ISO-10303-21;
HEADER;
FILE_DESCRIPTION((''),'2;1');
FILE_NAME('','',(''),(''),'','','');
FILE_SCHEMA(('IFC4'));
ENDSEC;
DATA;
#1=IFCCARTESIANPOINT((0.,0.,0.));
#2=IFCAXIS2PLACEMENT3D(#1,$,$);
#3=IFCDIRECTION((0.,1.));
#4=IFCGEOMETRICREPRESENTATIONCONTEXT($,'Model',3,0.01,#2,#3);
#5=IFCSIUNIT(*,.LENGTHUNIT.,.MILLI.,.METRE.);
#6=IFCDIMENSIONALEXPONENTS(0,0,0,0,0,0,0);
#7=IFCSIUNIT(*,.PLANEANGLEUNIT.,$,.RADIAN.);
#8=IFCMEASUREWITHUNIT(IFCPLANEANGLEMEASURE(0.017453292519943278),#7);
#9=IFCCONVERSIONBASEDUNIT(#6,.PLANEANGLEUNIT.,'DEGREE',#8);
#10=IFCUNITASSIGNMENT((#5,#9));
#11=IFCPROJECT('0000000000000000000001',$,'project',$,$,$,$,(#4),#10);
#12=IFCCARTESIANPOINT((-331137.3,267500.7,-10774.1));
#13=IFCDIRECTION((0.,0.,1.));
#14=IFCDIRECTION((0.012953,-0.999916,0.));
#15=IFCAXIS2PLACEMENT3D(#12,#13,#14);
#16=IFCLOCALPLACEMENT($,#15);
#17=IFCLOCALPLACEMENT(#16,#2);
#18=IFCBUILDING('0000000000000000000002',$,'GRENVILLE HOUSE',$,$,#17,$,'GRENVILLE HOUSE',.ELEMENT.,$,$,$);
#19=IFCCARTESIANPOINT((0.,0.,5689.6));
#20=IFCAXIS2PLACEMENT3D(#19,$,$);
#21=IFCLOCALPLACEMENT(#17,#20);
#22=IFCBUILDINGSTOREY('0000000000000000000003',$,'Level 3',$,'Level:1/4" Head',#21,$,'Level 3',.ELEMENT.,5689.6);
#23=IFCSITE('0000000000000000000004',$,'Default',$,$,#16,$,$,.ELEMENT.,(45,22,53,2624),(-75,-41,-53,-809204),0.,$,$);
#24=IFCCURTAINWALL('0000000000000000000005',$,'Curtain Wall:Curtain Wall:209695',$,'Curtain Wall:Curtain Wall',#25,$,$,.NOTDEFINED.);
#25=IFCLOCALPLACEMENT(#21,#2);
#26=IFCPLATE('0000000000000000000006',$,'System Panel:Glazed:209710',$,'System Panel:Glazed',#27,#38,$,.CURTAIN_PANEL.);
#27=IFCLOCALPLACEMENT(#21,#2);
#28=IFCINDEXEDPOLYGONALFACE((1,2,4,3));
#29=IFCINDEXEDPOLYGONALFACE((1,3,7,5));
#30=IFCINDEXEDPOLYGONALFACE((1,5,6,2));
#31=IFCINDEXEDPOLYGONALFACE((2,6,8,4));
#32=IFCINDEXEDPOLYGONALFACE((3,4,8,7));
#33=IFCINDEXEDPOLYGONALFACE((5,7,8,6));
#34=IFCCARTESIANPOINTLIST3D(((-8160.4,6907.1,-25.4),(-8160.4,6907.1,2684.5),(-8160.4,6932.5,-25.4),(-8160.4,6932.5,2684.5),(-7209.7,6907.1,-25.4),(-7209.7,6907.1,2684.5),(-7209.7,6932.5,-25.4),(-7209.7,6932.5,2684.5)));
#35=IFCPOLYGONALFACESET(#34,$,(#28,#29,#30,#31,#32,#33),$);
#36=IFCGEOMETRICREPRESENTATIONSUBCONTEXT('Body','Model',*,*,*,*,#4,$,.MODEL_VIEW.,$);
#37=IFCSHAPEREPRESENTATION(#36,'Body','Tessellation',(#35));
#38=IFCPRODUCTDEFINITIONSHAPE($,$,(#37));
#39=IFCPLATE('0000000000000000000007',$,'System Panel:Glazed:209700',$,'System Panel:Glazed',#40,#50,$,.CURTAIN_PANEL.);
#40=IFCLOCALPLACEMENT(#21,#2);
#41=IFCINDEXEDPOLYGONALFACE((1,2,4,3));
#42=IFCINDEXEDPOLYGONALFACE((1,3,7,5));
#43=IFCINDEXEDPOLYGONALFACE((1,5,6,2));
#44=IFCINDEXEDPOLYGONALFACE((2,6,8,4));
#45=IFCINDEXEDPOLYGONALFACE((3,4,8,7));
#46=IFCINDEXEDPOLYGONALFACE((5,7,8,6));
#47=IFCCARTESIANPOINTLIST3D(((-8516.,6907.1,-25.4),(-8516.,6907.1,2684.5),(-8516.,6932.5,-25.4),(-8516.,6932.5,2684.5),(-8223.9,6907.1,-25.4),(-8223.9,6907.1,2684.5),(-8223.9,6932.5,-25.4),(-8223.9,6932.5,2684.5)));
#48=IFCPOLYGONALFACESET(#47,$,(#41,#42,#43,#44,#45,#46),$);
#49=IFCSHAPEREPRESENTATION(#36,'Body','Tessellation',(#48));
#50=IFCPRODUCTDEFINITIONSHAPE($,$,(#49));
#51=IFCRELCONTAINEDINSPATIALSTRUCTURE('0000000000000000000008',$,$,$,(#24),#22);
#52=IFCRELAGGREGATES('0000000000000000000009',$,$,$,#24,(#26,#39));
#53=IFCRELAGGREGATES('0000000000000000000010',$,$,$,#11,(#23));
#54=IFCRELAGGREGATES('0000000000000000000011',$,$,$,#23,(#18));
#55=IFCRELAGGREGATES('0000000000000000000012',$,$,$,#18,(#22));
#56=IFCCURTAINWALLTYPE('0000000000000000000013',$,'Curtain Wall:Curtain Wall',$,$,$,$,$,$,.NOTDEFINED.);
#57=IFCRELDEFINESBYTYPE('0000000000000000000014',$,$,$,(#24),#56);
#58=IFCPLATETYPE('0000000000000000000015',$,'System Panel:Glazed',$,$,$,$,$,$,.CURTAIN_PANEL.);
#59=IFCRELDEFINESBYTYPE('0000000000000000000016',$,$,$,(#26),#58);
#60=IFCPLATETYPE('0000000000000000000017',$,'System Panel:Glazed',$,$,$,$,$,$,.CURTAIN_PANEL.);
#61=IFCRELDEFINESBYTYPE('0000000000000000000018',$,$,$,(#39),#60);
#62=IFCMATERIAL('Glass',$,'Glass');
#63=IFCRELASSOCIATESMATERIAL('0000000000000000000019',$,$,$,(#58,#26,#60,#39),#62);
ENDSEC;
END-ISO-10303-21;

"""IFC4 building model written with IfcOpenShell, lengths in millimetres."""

from ifc_helpers import new_model, entity, si_unit, converted_unit, direction, frame, origin, place, context, subcontext, project, spatial, indexed_curve, outline, extrude, source, transform, mapped, material, type_object, type_shapes, element, aggregate, save


model = new_model("IFC4")

# Units and contexts
model_context = context("Model", 3, precision=0.01, world=origin(), true_north=direction((0.0, 1.0)))
body_context = subcontext(model_context, "Body", "Model", "MODEL_VIEW")
ifc_project = project(units=[si_unit("LENGTHUNIT", "METRE", prefix="MILLI"), converted_unit("PLANEANGLEUNIT", "DEGREE", entity("IfcPlaneAngleMeasure", 0.017453292519943278), si_unit("PLANEANGLEUNIT", "RADIAN"), dimensions=[0, 0, 0, 0, 0, 0, 0])], contexts=[model_context])

# Site, building, storey
site_placement = place(None, frame((-331137.3, 267500.7, -10774.1), z_axis=(0.0, 0.0, 1.0), x_axis=(0.012953, -0.999916, 0.0)))
site = spatial("IfcSite", under=ifc_project, at=site_placement, Name="Default", CompositionType="ELEMENT", RefLatitude=(45, 22, 53, 2624), RefLongitude=(-75, -41, -53, -809204), RefElevation=0.0)
building_placement = place(site_placement, origin())
building = spatial("IfcBuilding", under=site, at=building_placement, Name="GRENVILLE HOUSE", LongName="GRENVILLE HOUSE", CompositionType="ELEMENT")
storey_placement = place(building_placement, frame((0.0, 0.0, 5689.6)))
storey = spatial("IfcBuildingStorey", under=building, at=storey_placement, Name="Level 3", ObjectType="Level:1/4\" Head", LongName="Level 3", CompositionType="ELEMENT", Elevation=5689.6)

# Curtain wall
curtain_wall_type = type_object("IfcCurtainWallType", Name="Curtain Wall:Curtain Wall", PredefinedType="NOTDEFINED")
curtain_wall_placement = place(storey_placement, frame((0.0, 0.0, -5689.6)))
curtain_wall = element("IfcCurtainWall", 1, at=curtain_wall_placement, inside=storey, type_object=curtain_wall_type, Name="Curtain Wall:Curtain Wall:209695", ObjectType="Curtain Wall:Curtain Wall", PredefinedType="NOTDEFINED")

# Plates
ifc_material_1 = material(Name="Glass", Category="Glass")
plate_type_1 = type_object("IfcPlateType", Name="System Panel:Glazed", PredefinedType="CURTAIN_PANEL", material=ifc_material_1)
shared_shape_1 = source(origin(), body_context, "Body", "SweptSolid", [
    extrude(outline(indexed_curve([(-12.7, -475.3), (12.7, -475.3), (12.7, 475.3), (-12.7, 475.3), (-12.7, -475.3)], self_intersect=False)), frame((475.3, 12.7, 0.0), z_axis=(0.0, 0.0, 1.0), x_axis=(0.0, 1.0, 0.0)), (0.0, 0.0, 1.0), 2709.9),
])
type_shapes(plate_type_1, [shared_shape_1])
plate_1_placement = place(curtain_wall_placement, frame((-7209.7, 6932.5, 5664.2), z_axis=(0.0, 0.0, 1.0), x_axis=(-1.0, 0.0, 0.0)))
plate_1 = element("IfcPlate", 2, at=plate_1_placement, type_object=plate_type_1, material=ifc_material_1, Name="System Panel:Glazed:209710", ObjectType="System Panel:Glazed", PredefinedType="CURTAIN_PANEL", context=body_context, shape_type="MappedRepresentation", body=[
    mapped(shared_shape_1, transform((0.0, 0.0, 0.0), scale=1.0)),
])
plate_type_2 = type_object("IfcPlateType", Name="System Panel:Glazed", PredefinedType="CURTAIN_PANEL", material=ifc_material_1)
shared_shape_2 = source(origin(), body_context, "Body", "SweptSolid", [
    extrude(outline(indexed_curve([(-12.7, -146.1), (12.7, -146.1), (12.7, 146.1), (-12.7, 146.1), (-12.7, -146.1)], self_intersect=False)), frame((146.1, 12.7, 0.0), z_axis=(0.0, 0.0, 1.0), x_axis=(0.0, 1.0, 0.0)), (0.0, 0.0, 1.0), 2709.9),
])
type_shapes(plate_type_2, [shared_shape_2])
plate_2_placement = place(curtain_wall_placement, frame((-8223.9, 6932.5, 5664.2), z_axis=(0.0, 0.0, 1.0), x_axis=(-1.0, 0.0, 0.0)))
plate_2 = element("IfcPlate", 3, at=plate_2_placement, type_object=plate_type_2, material=ifc_material_1, Name="System Panel:Glazed:209700", ObjectType="System Panel:Glazed", PredefinedType="CURTAIN_PANEL", context=body_context, shape_type="MappedRepresentation", body=[
    mapped(shared_shape_2, transform((0.0, 0.0, 0.0), scale=1.0)),
])
aggregate(curtain_wall, [plate_1, plate_2])

save(model, "model.ifc")
